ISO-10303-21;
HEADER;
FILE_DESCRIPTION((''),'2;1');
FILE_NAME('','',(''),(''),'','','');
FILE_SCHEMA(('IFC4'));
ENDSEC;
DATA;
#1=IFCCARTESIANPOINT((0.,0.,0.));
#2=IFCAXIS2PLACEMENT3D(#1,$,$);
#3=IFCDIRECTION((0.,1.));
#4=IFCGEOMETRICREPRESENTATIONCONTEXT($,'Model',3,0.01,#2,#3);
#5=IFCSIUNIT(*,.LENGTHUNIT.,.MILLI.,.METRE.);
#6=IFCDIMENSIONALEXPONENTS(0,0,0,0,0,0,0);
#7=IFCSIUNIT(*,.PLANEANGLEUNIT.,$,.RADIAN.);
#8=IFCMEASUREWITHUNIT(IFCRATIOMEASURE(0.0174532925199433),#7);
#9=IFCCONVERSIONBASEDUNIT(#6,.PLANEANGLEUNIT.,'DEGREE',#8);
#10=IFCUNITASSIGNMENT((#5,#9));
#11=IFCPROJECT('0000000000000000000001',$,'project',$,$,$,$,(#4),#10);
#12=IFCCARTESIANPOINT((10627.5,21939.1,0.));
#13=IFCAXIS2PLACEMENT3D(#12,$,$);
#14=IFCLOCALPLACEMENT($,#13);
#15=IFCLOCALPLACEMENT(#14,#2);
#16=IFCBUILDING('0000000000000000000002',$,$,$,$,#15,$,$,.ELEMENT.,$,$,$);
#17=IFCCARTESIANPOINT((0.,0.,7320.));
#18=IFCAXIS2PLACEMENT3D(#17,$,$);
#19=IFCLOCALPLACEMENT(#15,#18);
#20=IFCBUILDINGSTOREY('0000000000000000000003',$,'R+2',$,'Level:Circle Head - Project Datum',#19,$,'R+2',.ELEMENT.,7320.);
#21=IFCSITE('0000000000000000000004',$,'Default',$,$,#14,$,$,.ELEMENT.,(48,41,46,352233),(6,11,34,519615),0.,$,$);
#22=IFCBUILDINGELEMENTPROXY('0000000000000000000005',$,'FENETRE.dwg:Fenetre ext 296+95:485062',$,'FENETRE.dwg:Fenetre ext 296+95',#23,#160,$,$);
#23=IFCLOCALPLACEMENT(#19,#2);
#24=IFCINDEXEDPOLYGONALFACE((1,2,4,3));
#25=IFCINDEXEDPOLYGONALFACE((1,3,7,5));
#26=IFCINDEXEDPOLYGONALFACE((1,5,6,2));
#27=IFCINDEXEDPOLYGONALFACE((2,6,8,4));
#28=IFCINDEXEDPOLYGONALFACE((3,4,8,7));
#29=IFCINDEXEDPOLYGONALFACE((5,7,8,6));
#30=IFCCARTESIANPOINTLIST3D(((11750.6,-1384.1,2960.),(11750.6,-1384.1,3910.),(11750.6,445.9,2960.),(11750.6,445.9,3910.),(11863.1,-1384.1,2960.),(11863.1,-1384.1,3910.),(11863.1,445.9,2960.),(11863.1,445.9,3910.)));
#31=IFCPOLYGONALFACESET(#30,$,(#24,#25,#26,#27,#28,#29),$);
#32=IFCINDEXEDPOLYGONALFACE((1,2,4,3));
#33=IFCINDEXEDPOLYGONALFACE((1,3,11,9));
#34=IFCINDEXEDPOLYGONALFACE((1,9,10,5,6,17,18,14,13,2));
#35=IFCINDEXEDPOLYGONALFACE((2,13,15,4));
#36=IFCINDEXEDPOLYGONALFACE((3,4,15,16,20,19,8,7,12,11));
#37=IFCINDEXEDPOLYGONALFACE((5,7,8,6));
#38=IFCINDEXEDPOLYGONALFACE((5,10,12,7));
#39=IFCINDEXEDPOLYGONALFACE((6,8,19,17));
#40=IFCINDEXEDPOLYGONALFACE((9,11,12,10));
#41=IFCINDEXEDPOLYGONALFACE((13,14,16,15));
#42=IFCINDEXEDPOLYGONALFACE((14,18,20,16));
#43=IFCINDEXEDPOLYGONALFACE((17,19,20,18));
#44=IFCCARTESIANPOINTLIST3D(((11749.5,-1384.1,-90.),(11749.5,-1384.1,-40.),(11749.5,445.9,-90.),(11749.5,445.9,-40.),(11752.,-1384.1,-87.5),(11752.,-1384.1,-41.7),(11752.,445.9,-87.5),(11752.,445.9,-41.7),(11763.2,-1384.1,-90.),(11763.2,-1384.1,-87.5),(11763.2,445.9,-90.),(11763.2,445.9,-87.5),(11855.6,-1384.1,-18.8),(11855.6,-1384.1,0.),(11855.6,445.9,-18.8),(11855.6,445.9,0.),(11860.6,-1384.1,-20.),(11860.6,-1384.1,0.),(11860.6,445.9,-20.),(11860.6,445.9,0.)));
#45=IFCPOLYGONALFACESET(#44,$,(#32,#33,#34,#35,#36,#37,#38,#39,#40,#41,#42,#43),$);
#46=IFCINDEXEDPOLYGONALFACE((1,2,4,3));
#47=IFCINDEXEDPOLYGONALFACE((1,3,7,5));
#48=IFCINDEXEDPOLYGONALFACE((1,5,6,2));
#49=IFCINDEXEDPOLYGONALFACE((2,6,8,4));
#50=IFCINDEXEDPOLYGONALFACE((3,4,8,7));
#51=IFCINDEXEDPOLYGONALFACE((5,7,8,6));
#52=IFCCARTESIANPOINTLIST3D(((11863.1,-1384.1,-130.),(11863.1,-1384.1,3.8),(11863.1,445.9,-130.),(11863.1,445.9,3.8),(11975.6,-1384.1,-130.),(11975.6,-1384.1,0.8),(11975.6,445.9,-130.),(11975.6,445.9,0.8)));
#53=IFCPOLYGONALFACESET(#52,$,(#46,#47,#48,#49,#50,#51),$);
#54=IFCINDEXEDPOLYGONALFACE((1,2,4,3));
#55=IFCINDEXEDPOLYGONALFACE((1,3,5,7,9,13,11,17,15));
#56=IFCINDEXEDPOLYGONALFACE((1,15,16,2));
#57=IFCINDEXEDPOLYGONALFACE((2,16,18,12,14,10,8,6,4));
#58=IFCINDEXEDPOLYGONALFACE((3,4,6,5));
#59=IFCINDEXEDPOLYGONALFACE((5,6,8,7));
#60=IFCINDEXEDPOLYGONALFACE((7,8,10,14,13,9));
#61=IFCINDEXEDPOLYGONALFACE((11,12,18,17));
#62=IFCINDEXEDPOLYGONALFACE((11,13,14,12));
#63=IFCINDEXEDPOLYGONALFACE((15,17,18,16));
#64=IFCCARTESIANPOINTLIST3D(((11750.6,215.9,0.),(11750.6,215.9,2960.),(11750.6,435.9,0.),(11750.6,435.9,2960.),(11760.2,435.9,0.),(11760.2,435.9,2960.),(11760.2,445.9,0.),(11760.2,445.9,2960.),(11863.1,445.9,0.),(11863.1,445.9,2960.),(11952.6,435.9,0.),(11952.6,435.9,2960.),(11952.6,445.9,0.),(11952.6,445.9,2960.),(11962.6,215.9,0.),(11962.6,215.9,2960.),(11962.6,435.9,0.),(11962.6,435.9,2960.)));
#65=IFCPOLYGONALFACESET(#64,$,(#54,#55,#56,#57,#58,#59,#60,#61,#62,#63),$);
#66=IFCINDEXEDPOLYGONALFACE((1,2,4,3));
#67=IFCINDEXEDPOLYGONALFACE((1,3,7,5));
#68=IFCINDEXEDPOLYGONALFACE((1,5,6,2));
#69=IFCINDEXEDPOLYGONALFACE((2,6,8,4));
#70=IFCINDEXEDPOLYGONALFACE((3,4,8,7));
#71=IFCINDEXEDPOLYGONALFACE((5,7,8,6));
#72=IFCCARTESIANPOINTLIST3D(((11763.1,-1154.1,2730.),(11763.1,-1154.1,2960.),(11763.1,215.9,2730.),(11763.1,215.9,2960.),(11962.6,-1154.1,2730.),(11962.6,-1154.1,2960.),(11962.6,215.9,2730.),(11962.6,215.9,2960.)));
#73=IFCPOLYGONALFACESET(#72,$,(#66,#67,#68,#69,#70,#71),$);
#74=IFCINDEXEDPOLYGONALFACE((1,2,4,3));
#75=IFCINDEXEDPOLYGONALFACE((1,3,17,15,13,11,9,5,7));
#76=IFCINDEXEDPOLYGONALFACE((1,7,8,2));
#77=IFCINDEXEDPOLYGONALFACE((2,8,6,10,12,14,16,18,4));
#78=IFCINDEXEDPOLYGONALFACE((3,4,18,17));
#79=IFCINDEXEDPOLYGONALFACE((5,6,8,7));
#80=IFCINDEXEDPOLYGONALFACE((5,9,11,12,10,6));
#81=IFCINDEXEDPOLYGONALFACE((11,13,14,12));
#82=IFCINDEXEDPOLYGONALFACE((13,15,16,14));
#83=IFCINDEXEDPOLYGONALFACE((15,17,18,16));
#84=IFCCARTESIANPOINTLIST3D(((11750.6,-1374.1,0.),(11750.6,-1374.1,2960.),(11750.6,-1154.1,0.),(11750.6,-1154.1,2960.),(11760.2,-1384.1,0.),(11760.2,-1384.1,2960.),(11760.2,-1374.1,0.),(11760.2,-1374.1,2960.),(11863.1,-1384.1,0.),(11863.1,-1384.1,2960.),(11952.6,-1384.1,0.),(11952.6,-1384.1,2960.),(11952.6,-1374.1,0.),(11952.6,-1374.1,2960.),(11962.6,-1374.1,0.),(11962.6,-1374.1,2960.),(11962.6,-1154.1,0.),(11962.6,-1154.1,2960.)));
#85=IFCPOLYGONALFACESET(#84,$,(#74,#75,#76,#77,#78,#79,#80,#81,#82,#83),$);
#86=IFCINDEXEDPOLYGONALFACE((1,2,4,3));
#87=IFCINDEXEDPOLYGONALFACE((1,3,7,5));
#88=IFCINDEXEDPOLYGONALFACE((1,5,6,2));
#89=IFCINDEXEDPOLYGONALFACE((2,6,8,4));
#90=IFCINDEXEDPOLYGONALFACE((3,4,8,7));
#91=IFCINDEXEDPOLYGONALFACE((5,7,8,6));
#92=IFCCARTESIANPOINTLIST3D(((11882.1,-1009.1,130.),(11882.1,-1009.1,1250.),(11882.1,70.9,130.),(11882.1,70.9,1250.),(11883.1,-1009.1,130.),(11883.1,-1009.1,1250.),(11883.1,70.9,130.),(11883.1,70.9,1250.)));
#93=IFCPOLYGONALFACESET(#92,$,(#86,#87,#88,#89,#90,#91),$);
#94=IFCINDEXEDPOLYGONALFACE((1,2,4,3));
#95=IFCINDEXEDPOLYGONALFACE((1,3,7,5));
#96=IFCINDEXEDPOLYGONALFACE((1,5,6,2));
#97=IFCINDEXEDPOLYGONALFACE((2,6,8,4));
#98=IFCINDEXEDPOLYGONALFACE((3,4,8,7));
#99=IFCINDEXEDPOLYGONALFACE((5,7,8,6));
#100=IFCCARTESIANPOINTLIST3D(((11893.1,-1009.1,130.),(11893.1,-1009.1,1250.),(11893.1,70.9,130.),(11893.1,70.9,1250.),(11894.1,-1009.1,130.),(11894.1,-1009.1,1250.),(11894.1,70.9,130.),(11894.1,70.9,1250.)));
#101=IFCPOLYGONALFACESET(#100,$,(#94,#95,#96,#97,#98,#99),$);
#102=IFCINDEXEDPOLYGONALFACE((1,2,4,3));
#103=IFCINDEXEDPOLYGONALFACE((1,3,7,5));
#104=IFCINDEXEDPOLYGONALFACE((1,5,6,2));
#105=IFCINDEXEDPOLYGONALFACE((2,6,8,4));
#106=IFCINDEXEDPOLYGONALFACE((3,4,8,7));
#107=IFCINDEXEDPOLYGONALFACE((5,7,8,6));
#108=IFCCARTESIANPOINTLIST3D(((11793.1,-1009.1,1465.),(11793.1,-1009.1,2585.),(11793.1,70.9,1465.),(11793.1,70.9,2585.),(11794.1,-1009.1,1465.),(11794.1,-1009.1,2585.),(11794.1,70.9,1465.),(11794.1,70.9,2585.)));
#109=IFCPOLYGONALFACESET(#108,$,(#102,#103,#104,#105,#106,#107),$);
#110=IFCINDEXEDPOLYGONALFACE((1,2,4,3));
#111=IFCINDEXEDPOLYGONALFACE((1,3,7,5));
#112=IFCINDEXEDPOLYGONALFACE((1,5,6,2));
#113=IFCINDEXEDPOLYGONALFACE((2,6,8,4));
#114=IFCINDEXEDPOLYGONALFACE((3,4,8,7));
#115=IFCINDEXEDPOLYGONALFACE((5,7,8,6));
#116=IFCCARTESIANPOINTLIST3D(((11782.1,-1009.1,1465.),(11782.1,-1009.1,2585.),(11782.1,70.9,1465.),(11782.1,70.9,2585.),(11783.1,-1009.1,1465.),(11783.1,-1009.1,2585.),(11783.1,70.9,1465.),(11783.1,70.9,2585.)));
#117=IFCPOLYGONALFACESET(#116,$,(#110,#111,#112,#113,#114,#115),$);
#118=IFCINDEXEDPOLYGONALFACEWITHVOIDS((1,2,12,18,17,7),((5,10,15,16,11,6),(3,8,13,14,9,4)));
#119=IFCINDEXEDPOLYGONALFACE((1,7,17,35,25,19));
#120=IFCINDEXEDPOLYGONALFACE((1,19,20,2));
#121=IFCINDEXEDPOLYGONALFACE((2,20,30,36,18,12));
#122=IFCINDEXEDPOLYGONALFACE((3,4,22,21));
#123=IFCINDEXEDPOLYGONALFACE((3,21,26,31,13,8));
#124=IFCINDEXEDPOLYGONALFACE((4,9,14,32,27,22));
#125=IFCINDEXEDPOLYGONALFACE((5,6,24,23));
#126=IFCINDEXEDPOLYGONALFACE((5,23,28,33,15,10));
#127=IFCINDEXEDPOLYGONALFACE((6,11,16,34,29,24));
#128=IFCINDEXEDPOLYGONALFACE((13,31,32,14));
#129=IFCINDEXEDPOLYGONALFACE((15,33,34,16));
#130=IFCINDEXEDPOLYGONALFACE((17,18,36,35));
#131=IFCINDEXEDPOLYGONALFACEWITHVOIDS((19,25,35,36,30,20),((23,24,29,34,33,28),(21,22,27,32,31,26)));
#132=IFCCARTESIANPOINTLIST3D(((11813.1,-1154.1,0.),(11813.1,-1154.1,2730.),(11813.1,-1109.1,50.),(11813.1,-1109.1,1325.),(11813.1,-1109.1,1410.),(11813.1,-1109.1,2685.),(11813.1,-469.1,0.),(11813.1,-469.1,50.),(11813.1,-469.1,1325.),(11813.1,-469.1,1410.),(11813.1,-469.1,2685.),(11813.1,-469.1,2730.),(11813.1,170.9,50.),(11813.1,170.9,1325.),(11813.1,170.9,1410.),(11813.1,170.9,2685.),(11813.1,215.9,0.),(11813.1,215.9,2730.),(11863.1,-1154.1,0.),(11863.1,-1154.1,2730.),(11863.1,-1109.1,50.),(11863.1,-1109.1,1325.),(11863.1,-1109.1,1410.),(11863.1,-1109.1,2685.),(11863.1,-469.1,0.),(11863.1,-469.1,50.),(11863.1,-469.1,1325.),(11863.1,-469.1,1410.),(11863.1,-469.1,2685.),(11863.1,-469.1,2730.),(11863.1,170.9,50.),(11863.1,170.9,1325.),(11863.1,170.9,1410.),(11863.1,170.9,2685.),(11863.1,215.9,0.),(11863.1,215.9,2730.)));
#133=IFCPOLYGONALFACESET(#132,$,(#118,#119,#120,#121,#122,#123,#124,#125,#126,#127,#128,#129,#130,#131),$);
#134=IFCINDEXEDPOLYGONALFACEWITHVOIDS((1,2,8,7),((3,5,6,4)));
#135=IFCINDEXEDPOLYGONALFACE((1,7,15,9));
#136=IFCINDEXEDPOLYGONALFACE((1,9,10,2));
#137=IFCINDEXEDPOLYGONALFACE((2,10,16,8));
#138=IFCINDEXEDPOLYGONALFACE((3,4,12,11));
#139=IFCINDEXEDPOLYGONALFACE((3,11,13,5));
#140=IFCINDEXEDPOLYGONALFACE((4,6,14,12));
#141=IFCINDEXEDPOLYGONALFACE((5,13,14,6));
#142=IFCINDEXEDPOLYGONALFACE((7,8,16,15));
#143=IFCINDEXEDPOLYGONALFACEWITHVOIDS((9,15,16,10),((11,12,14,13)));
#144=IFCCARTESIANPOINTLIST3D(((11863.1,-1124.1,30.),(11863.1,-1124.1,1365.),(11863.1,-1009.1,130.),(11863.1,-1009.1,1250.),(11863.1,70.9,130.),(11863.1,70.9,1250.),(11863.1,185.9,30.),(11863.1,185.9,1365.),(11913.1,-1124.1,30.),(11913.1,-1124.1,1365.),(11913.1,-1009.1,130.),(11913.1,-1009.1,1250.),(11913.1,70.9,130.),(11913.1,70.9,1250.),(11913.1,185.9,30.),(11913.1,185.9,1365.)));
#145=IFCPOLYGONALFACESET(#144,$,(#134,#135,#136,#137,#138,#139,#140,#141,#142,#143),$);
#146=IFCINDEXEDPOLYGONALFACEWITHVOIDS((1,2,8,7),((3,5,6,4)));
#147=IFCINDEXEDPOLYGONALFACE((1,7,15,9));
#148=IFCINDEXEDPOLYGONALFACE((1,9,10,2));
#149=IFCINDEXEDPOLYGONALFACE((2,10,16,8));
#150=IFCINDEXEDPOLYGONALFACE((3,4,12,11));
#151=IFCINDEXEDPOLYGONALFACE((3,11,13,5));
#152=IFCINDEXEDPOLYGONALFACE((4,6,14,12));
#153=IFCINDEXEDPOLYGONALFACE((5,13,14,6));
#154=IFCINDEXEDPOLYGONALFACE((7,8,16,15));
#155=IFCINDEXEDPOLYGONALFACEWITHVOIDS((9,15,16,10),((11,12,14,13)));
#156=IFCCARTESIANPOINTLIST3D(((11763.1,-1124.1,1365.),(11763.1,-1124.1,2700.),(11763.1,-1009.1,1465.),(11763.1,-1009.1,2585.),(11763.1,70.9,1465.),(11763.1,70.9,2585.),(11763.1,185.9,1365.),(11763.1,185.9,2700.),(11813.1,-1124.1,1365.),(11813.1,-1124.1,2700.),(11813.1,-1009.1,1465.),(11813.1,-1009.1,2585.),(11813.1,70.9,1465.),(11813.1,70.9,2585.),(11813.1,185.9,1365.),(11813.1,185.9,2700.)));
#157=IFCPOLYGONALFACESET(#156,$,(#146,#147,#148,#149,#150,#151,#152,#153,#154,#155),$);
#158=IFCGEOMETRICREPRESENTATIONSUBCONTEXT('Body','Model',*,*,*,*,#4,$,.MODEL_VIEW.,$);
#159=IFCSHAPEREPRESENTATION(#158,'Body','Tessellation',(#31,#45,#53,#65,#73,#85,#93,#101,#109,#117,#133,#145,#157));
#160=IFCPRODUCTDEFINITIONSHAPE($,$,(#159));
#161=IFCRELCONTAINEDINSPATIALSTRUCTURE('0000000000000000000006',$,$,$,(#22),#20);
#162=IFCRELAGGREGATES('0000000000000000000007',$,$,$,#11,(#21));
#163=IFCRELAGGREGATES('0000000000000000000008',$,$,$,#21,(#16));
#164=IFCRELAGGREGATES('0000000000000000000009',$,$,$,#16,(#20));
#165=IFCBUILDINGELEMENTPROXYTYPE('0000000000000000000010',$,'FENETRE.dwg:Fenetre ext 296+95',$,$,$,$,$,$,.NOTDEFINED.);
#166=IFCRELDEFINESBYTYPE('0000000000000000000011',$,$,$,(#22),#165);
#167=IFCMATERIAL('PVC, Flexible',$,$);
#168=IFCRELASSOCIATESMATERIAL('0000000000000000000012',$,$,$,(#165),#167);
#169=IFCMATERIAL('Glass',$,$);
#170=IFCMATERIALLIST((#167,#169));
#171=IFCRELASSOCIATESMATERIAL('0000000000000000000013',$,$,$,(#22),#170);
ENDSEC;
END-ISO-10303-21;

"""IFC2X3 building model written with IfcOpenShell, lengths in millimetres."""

from ifc_helpers import new_model, entity, si_unit, converted_unit, direction, frame, frame_2d, origin, origin_2d_with_axis, place, context, subcontext, project, spatial, polyline, rectangle, outline, extrude, source, transform, mapped, material, material_list, type_object, type_shapes, element, save


model = new_model("IFC2X3")

# Units and contexts
model_context = context("Model", 3, precision=0.01, world=origin(), true_north=direction((0.0, 1.0)))
body_context = subcontext(model_context, "Body", "Model", "MODEL_VIEW")
ifc_project = project(units=[si_unit("LENGTHUNIT", "METRE", prefix="MILLI"), converted_unit("PLANEANGLEUNIT", "DEGREE", entity("IfcRatioMeasure", 0.0174532925199433), si_unit("PLANEANGLEUNIT", "RADIAN"), dimensions=[0, 0, 0, 0, 0, 0, 0])], contexts=[model_context])

# Site, building, storey
site_placement = place(None, frame((10627.5, 21939.1, 0.0)))
site = spatial("IfcSite", under=ifc_project, at=site_placement, Name="Default", CompositionType="ELEMENT", RefLatitude=(48, 41, 46, 352233), RefLongitude=(6, 11, 34, 519615), RefElevation=0.0)
building_placement = place(site_placement, origin())
building = spatial("IfcBuilding", under=site, at=building_placement, CompositionType="ELEMENT")
storey_placement = place(building_placement, frame((0.0, 0.0, 7320.0)))
storey = spatial("IfcBuildingStorey", under=building, at=storey_placement, Name="R+2", ObjectType="Level:Circle Head - Project Datum", LongName="R+2", CompositionType="ELEMENT", Elevation=7320.0)

# Building element proxy
ifc_material_1 = material(Name="PVC, Flexible")
ifc_material_2 = material(Name="Glass")
building_element_proxy_type_1 = type_object("IfcBuildingElementProxyType", Name="FENETRE.dwg:Fenetre ext 296+95", PredefinedType="NOTDEFINED", material=ifc_material_1)
shared_shape_1 = source(origin(), body_context, "Body", "SweptSolid", [
    extrude(rectangle(XDim=1830.0, YDim=112.5, at=origin_2d_with_axis()), frame((-10.4, 56.3, 2960.0), z_axis=(0.0, 0.0, 1.0), x_axis=(-1.0, 0.0, 0.0)), (0.0, 0.0, 1.0), 950.0),
    extrude(outline(polyline([(-68.6, -14.4), (-72.5, -34.0), (-67.6, -35.0), (-63.9, -16.6), (44.3, -16.6), (54.1, 32.5), (40.6, 35.2), (40.1, 32.7), (51.2, 30.5), (42.2, -14.4), (-68.6, -14.4)])), frame((-925.4, 66.9, -47.5), z_axis=(-1.0, 0.0, 0.0), x_axis=(0.0, 0.980599, -0.196027)), (0.0, 0.0, -1.0), 1830.0),
    extrude(outline(polyline([(-64.7, -56.3), (66.2, -56.3), (66.2, 56.3), (-67.7, 56.3), (-64.7, -56.3)])), frame((-925.4, -56.3, -63.8), z_axis=(1.0, 0.0, 0.0), x_axis=(0.0, 0.0, -1.0)), (0.0, 0.0, 1.0), 1830.0),
    extrude(outline(polyline([(-55.6, 97.0), (-55.6, -5.9), (-55.6, -95.4), (-45.6, -95.4), (-45.6, -105.4), (174.4, -105.4), (174.4, 106.6), (-45.6, 106.6), (-45.6, 97.0), (-55.6, 97.0)])), frame((849.0, 5.9, 0.0), z_axis=(0.0, 0.0, -1.0), x_axis=(-1.0, 0.0, 0.0)), (0.0, 0.0, -1.0), 2960.0),
    extrude(rectangle(XDim=199.5, YDim=1370.0, at=origin_2d_with_axis()), frame((-10.4, 0.3, 2730.0), z_axis=(0.0, 0.0, 1.0), x_axis=(0.0, 1.0, 0.0)), (0.0, 0.0, 1.0), 230.0),
    extrude(outline(polyline([(-97.0, -55.6), (5.9, -55.6), (95.4, -55.6), (95.4, -45.6), (105.4, -45.6), (105.4, 174.4), (-106.6, 174.4), (-106.6, -45.6), (-97.0, -45.6), (-97.0, -55.6)])), frame((-869.9, 5.9, 0.0), z_axis=(0.0, 0.0, 1.0), x_axis=(0.0, -1.0, 0.0)), (0.0, 0.0, 1.0), 2960.0),
    extrude(rectangle(XDim=1.0, YDim=1080.0, at=origin_2d_with_axis()), frame((-10.4, -19.5, 130.0), z_axis=(0.0, 0.0, 1.0), x_axis=(0.0, 1.0, 0.0)), (0.0, 0.0, 1.0), 1120.0),
    extrude(rectangle(XDim=1.0, YDim=1080.0, at=frame_2d((0.0, 0.0), x_axis=(1.0, 0.0))), frame((-10.4, -30.5, 130.0), z_axis=(0.0, 0.0, 1.0), x_axis=(0.0, 1.0, 0.0)), (0.0, 0.0, 1.0), 1120.0),
    extrude(rectangle(XDim=1.0, YDim=1080.0, at=frame_2d((0.0, 0.0), x_axis=(1.0, 0.0))), frame((-10.4, 69.5, 1465.0), z_axis=(0.0, 0.0, 1.0), x_axis=(0.0, 1.0, 0.0)), (0.0, 0.0, 1.0), 1120.0),
    extrude(rectangle(XDim=1.0, YDim=1080.0, at=frame_2d((0.0, 0.0), x_axis=(1.0, 0.0))), frame((-10.4, 80.5, 1465.0), z_axis=(0.0, 0.0, 1.0), x_axis=(0.0, 1.0, 0.0)), (0.0, 0.0, 1.0), 1120.0),
    extrude(outline(polyline([(-685.0, -1365.0), (0.0, -1365.0), (685.0, -1365.0), (685.0, 1365.0), (0.0, 1365.0), (-685.0, 1365.0), (-685.0, -1365.0)]), holes=[polyline([(-640.0, -1320.0), (-640.0, -45.0), (0.0, -45.0), (640.0, -45.0), (640.0, -1320.0), (0.0, -1320.0), (-640.0, -1320.0)]), polyline([(-640.0, 40.0), (-640.0, 1315.0), (0.0, 1315.0), (640.0, 1315.0), (640.0, 40.0), (0.0, 40.0), (-640.0, 40.0)])]), frame((-10.4, 0.0, 1365.0), z_axis=(0.0, 1.0, 0.0), x_axis=(1.0, 0.0, 0.0)), (0.0, 0.0, 1.0), 50.0),
    extrude(outline(polyline([(-655.0, -667.5), (655.0, -667.5), (655.0, 667.5), (-655.0, 667.5), (-655.0, -667.5)]), holes=[polyline([(-540.0, 552.5), (540.0, 552.5), (540.0, -567.5), (-540.0, -567.5), (-540.0, 552.5)])]), frame((-10.4, -50.0, 697.5), z_axis=(0.0, 1.0, 0.0), x_axis=(-1.0, 0.0, 0.0)), (0.0, 0.0, 1.0), 50.0),
    extrude(outline(polyline([(-655.0, -667.5), (655.0, -667.5), (655.0, 667.5), (-655.0, 667.5), (-655.0, -667.5)]), holes=[polyline([(-540.0, 552.5), (540.0, 552.5), (540.0, -567.5), (-540.0, -567.5), (-540.0, 552.5)])]), frame((-10.4, 50.0, 2032.5), z_axis=(0.0, 1.0, 0.0), x_axis=(-1.0, 0.0, 0.0)), (0.0, 0.0, 1.0), 50.0),
])
type_shapes(building_element_proxy_type_1, [shared_shape_1])
ifc_material_list_1 = material_list([ifc_material_1, ifc_material_2])
proxy_1_placement = place(storey_placement, frame((11863.1, -458.7, 0.0), z_axis=(0.0, 0.0, 1.0), x_axis=(0.0, 1.0, 0.0)))
element("IfcBuildingElementProxy", 1, at=proxy_1_placement, inside=storey, type_object=building_element_proxy_type_1, material=ifc_material_list_1, Name="FENETRE.dwg:Fenetre ext 296+95:485062", ObjectType="FENETRE.dwg:Fenetre ext 296+95", context=body_context, shape_type="MappedRepresentation", body=[
    mapped(shared_shape_1, transform((0.0, 0.0, 0.0), scale=1.0)),
])

save(model, "model.ifc")
